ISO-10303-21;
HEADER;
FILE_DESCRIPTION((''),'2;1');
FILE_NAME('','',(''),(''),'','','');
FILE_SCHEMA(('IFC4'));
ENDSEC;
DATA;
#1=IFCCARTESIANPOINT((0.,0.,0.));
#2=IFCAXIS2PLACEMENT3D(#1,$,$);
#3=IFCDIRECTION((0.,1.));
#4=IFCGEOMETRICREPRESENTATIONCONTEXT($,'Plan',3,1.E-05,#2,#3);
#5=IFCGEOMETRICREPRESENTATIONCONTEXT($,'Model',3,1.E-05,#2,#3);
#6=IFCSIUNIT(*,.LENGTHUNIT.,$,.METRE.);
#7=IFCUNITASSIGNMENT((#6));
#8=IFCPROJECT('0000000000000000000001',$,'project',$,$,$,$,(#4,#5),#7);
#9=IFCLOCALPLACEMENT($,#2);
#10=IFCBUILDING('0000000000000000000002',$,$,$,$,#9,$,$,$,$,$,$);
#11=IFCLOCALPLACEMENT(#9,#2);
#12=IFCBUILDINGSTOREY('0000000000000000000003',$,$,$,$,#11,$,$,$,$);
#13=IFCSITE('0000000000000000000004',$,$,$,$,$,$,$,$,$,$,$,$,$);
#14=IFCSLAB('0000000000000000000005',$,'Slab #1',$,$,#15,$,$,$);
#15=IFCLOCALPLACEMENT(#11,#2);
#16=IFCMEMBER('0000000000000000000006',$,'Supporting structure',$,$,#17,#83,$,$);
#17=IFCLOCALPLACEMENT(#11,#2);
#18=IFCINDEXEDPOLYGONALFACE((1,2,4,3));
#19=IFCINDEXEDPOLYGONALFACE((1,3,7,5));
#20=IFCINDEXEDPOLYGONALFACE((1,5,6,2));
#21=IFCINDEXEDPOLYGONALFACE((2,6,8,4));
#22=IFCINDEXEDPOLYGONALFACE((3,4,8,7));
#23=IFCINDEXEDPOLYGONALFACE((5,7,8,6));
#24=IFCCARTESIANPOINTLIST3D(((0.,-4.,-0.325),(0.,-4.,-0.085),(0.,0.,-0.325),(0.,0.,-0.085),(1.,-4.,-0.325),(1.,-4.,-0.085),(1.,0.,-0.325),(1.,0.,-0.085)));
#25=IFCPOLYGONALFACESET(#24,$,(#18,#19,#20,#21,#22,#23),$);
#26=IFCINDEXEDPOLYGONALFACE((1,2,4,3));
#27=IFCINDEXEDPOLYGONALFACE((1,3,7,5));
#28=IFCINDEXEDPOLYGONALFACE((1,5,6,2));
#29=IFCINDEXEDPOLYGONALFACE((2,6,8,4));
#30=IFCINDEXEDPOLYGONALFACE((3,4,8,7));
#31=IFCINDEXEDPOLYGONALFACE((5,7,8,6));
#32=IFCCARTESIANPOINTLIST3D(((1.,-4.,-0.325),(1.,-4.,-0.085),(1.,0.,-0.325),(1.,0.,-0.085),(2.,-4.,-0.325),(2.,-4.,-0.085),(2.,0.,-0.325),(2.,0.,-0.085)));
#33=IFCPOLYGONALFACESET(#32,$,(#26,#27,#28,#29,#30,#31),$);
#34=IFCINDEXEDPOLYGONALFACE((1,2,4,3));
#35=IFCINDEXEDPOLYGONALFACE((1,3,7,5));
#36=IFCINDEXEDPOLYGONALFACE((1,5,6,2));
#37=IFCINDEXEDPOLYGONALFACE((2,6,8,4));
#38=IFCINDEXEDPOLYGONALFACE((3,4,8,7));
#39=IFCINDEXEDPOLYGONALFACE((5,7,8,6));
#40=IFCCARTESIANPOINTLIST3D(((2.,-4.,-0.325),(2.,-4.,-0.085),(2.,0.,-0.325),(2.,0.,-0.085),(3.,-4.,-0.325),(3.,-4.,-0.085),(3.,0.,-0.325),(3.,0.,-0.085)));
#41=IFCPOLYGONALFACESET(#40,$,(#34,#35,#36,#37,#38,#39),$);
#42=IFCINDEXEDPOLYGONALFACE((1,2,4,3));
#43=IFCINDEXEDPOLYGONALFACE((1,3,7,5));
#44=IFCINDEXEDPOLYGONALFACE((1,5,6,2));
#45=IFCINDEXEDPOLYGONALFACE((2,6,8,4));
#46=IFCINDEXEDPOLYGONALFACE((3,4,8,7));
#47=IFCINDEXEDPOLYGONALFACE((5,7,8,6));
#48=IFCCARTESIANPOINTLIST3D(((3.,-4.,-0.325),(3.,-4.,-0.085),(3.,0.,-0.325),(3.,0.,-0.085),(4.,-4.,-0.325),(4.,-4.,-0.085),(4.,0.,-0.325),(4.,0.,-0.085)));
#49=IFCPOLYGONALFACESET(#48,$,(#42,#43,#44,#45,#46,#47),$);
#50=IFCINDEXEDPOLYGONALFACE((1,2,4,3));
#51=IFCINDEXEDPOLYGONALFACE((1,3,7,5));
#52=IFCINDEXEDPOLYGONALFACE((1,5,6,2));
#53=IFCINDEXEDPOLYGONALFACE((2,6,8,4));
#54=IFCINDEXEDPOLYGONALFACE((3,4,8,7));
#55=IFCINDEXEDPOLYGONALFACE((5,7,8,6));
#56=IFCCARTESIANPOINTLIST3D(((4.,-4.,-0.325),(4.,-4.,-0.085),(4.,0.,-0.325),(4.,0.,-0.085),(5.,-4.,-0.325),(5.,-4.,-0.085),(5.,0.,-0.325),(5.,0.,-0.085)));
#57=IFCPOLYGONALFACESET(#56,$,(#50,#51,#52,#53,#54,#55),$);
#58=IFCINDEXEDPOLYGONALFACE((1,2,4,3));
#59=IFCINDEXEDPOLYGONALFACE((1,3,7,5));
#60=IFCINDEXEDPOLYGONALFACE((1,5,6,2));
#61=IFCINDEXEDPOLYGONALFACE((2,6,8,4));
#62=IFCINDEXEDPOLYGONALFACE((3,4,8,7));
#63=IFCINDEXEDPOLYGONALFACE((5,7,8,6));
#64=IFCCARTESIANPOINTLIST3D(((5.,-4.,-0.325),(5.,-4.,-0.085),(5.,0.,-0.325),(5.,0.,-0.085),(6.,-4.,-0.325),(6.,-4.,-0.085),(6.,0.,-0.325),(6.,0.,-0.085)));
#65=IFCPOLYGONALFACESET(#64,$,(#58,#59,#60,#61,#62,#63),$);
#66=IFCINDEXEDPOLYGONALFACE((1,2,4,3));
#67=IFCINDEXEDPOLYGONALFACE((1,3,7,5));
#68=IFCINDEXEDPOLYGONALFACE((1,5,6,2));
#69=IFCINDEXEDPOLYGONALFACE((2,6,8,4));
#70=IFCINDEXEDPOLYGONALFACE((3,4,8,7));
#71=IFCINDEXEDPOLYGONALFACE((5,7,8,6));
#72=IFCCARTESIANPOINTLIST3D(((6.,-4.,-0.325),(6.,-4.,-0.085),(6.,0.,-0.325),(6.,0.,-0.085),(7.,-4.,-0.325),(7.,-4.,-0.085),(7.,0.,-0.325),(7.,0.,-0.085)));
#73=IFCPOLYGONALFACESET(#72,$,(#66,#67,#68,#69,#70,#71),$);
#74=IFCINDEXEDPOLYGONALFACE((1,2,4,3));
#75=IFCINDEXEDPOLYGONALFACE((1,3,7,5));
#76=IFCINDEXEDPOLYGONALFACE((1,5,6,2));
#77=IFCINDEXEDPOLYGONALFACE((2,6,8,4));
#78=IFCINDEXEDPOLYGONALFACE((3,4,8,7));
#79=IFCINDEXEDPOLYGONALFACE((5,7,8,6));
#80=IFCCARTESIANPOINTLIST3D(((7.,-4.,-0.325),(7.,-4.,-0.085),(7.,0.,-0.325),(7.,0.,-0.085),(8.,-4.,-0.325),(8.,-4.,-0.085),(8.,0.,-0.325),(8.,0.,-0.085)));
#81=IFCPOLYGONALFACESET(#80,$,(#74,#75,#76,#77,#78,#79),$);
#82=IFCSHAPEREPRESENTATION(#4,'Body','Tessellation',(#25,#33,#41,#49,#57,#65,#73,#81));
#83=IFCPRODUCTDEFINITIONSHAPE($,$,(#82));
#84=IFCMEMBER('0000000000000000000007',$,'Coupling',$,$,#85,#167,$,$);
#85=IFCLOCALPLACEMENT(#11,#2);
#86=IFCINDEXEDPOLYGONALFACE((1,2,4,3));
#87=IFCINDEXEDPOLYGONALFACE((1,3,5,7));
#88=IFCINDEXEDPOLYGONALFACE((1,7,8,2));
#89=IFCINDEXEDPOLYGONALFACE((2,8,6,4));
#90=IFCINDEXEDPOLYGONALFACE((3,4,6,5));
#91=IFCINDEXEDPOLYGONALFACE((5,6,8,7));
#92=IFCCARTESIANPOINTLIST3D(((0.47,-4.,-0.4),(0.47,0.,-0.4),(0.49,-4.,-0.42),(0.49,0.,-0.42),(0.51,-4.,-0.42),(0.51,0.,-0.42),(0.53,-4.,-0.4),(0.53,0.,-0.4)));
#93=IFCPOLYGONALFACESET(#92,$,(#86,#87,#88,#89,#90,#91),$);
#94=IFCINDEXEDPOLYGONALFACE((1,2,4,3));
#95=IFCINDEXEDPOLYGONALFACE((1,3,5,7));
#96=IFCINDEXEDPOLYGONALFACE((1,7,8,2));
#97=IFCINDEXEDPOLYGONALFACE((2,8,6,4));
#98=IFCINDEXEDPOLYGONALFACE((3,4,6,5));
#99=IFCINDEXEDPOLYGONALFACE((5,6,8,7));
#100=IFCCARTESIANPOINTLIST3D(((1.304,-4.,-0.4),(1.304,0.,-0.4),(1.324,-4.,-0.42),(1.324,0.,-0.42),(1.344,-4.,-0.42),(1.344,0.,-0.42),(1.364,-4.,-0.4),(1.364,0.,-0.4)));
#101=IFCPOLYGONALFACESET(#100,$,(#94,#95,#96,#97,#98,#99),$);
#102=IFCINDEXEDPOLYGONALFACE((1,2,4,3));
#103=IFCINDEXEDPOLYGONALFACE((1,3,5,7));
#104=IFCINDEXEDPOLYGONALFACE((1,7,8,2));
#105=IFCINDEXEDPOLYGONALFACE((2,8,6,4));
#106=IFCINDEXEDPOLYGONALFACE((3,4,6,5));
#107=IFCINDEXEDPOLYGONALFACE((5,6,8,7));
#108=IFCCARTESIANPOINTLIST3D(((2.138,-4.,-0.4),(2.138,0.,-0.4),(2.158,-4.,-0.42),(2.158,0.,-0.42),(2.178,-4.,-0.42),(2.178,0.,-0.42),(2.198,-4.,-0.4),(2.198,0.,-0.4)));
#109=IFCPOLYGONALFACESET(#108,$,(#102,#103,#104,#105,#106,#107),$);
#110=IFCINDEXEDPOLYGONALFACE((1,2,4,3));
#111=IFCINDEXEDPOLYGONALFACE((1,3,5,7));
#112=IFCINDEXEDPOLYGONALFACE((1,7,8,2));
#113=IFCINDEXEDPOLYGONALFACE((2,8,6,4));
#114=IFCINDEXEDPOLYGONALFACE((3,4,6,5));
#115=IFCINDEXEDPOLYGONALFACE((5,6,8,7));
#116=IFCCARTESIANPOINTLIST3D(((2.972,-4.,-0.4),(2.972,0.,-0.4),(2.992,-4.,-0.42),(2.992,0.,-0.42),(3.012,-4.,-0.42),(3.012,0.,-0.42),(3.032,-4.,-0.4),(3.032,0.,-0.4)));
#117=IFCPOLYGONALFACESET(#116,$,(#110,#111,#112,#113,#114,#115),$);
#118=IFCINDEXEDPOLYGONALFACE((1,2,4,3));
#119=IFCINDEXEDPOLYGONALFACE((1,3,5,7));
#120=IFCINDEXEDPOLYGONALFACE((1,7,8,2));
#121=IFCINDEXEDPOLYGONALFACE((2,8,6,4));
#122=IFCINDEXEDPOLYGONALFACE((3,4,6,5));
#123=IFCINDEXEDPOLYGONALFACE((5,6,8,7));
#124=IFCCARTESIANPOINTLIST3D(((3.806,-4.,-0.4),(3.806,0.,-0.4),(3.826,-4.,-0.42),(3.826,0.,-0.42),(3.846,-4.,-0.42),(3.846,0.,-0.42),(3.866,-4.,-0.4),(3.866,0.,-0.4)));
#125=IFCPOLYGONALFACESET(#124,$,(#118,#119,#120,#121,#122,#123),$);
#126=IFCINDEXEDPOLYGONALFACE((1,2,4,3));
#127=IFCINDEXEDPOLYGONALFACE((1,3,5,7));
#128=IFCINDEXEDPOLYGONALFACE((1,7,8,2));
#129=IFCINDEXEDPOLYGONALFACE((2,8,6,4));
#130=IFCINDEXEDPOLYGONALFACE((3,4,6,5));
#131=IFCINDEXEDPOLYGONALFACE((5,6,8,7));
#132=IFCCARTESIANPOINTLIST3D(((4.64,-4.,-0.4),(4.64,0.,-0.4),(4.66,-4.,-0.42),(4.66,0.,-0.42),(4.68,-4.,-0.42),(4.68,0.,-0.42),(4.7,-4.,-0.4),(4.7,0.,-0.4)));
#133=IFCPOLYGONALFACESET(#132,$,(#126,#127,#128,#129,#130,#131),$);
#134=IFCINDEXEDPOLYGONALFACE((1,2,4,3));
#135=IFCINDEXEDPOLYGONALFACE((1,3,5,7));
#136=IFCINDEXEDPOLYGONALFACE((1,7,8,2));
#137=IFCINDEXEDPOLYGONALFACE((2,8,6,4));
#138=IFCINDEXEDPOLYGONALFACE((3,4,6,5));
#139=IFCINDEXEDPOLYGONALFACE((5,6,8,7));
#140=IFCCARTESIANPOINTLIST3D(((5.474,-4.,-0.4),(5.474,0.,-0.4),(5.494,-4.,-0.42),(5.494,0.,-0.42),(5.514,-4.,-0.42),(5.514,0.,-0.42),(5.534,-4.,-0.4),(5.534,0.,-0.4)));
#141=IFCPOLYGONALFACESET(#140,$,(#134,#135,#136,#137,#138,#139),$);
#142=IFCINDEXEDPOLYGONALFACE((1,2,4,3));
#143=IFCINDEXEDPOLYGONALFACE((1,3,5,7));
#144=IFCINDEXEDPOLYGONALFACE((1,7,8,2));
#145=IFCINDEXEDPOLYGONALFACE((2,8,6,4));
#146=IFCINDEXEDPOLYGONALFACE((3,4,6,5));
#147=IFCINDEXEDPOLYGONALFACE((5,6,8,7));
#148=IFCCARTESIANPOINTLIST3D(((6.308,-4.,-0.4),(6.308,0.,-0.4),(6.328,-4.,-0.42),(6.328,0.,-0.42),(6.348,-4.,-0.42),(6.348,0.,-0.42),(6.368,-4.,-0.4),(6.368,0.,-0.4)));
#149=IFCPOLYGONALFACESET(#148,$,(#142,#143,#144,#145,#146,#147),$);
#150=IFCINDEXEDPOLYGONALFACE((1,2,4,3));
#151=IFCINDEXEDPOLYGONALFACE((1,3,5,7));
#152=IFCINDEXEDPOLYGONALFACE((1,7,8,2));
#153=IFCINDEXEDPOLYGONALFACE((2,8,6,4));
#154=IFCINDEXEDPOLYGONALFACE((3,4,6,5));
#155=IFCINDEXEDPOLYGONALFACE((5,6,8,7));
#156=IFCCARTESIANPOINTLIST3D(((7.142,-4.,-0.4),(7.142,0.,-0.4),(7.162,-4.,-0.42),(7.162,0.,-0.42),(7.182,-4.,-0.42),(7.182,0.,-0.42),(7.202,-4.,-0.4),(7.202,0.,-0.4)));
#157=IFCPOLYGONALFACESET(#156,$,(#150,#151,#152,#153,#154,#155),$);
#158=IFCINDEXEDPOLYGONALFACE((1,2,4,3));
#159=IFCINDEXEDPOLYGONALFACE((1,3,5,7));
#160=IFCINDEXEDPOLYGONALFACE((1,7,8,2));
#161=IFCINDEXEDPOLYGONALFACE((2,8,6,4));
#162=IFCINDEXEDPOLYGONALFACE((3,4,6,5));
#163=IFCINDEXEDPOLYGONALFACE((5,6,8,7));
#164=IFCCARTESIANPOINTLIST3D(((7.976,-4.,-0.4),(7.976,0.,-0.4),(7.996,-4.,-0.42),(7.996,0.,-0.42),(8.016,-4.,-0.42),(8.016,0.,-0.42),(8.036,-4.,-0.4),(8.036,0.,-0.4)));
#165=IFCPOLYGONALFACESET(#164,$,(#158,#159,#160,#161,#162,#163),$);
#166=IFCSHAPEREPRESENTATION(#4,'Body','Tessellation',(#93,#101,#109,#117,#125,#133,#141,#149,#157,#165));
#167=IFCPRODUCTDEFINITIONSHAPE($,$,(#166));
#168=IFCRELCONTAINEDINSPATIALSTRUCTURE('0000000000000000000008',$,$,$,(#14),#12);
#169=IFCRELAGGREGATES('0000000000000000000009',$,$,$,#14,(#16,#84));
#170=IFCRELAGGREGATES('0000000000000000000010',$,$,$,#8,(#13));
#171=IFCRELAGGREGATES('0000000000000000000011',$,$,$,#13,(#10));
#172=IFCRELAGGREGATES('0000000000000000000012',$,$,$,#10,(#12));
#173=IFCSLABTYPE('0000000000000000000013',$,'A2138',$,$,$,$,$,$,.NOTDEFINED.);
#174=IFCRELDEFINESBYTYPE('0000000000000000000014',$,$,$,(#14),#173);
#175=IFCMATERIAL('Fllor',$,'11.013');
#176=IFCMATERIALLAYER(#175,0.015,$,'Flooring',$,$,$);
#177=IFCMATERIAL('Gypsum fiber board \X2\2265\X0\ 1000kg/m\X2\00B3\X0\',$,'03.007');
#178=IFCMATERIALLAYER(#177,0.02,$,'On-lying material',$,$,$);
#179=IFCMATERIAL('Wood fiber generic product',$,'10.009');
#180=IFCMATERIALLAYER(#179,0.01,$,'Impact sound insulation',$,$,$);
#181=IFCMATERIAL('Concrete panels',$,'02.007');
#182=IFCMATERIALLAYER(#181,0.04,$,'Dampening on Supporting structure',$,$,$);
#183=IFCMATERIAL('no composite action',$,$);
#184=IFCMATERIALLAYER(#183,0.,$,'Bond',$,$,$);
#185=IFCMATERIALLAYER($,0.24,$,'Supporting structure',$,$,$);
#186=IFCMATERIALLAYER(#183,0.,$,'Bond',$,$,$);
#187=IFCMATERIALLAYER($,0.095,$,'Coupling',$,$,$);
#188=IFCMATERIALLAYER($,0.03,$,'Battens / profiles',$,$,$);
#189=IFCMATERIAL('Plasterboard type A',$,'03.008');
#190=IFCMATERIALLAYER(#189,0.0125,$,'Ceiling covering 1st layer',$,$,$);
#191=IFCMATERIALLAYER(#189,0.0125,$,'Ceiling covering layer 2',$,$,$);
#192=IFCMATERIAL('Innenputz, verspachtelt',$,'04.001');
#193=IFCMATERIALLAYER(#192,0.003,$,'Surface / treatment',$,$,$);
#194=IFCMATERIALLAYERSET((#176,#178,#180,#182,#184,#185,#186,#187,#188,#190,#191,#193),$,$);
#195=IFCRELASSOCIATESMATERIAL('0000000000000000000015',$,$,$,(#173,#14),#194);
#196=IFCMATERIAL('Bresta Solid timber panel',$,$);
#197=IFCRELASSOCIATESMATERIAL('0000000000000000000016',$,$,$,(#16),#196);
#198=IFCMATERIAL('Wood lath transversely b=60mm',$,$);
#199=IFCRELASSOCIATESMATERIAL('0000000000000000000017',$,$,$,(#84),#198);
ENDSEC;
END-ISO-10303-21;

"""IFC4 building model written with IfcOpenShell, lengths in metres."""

from ifc_helpers import new_model, si_unit, direction, frame, frame_2d, origin, place, context, project, spatial, polyline, rectangle, outline, extrude, material, layer, layer_set, type_object, element, aggregate, save


model = new_model("IFC4")

# Units and contexts
plan_context = context("Plan", 3, precision=1e-05, world=origin(), true_north=direction((0.0, 1.0)))
model_context = context("Model", 3, precision=1e-05, world=origin(), true_north=direction((0.0, 1.0)))
ifc_project = project(units=[si_unit("LENGTHUNIT", "METRE")], contexts=[plan_context, model_context])

# Site, building, storey
site = spatial("IfcSite", under=ifc_project)
building_placement = place(None, origin())
building = spatial("IfcBuilding", under=site, at=building_placement)
storey_placement = place(building_placement, origin())
storey = spatial("IfcBuildingStorey", under=building, at=storey_placement)

# Slab, members
ifc_material_1 = material(Name="Fllor", Category="11.013")
ifc_layer_1 = layer(ifc_material_1, 0.015, Name="Flooring")
ifc_material_2 = material(Name="Gypsum fiber board ≥ 1000kg/m³", Category="03.007")
ifc_layer_2 = layer(ifc_material_2, 0.02, Name="On-lying material")
ifc_material_3 = material(Name="Wood fiber generic product", Category="10.009")
ifc_layer_3 = layer(ifc_material_3, 0.01, Name="Impact sound insulation")
ifc_material_4 = material(Name="Concrete panels", Category="02.007")
ifc_layer_4 = layer(ifc_material_4, 0.04, Name="Dampening on Supporting structure")
ifc_material_5 = material(Name="no composite action")
ifc_layer_5 = layer(ifc_material_5, 0.0, Name="Bond")
ifc_layer_6 = layer(None, 0.24, Name="Supporting structure")
ifc_layer_7 = layer(ifc_material_5, 0.0, Name="Bond")
ifc_layer_8 = layer(None, 0.095, Name="Coupling")
ifc_layer_9 = layer(None, 0.03, Name="Battens / profiles")
ifc_material_6 = material(Name="Plasterboard type A", Category="03.008")
ifc_layer_10 = layer(ifc_material_6, 0.0125, Name="Ceiling covering 1st layer")
ifc_layer_11 = layer(ifc_material_6, 0.0125, Name="Ceiling covering layer 2")
ifc_material_7 = material(Name="Innenputz, verspachtelt", Category="04.001")
ifc_layer_12 = layer(ifc_material_7, 0.003, Name="Surface / treatment")
ifc_layer_set = layer_set([ifc_layer_1, ifc_layer_2, ifc_layer_3, ifc_layer_4, ifc_layer_5, ifc_layer_6, ifc_layer_7, ifc_layer_8, ifc_layer_9, ifc_layer_10, ifc_layer_11, ifc_layer_12])
slab_type = type_object("IfcSlabType", Name="A2138", PredefinedType="NOTDEFINED", material=ifc_layer_set)
slab_placement = place(None, frame((0.0, 0.0, 0.0), z_axis=(0.0, 0.0, -1.0), x_axis=(1.0, 0.0, 0.0)))
slab = element("IfcSlab", 1, at=slab_placement, inside=storey, type_object=slab_type, material=ifc_layer_set, Name="Slab #1")
ifc_material_8 = material(Name="Bresta Solid timber panel")
member_1_placement = place(slab_placement, origin())
member_1 = element("IfcMember", 2, at=member_1_placement, material=ifc_material_8, Name="Supporting structure", context=plan_context, shape_type="SweptSolid", body=[
    extrude(rectangle(XDim=1.0, YDim=0.24, at=frame_2d((0.5, 0.12), x_axis=(1.0, 0.0))), frame((0.0, 4.0, 0.085), z_axis=(0.0, -1.0, 0.0), x_axis=(1.0, 0.0, 0.0)), (0.0, 0.0, 1.0), 4.0),
    extrude(rectangle(XDim=1.0, YDim=0.24, at=frame_2d((0.5, 0.12), x_axis=(1.0, 0.0))), frame((1.0, 4.0, 0.085), z_axis=(0.0, -1.0, 0.0), x_axis=(1.0, 0.0, 0.0)), (0.0, 0.0, 1.0), 4.0),
    extrude(rectangle(XDim=1.0, YDim=0.24, at=frame_2d((0.5, 0.12), x_axis=(1.0, 0.0))), frame((2.0, 4.0, 0.085), z_axis=(0.0, -1.0, 0.0), x_axis=(1.0, 0.0, 0.0)), (0.0, 0.0, 1.0), 4.0),
    extrude(rectangle(XDim=1.0, YDim=0.24, at=frame_2d((0.5, 0.12), x_axis=(1.0, 0.0))), frame((3.0, 4.0, 0.085), z_axis=(0.0, -1.0, 0.0), x_axis=(1.0, 0.0, 0.0)), (0.0, 0.0, 1.0), 4.0),
    extrude(rectangle(XDim=1.0, YDim=0.24, at=frame_2d((0.5, 0.12), x_axis=(1.0, 0.0))), frame((4.0, 4.0, 0.085), z_axis=(0.0, -1.0, 0.0), x_axis=(1.0, 0.0, 0.0)), (0.0, 0.0, 1.0), 4.0),
    extrude(rectangle(XDim=1.0, YDim=0.24, at=frame_2d((0.5, 0.12), x_axis=(1.0, 0.0))), frame((5.0, 4.0, 0.085), z_axis=(0.0, -1.0, 0.0), x_axis=(1.0, 0.0, 0.0)), (0.0, 0.0, 1.0), 4.0),
    extrude(rectangle(XDim=1.0, YDim=0.24, at=frame_2d((0.5, 0.12), x_axis=(1.0, 0.0))), frame((6.0, 4.0, 0.085), z_axis=(0.0, -1.0, 0.0), x_axis=(1.0, 0.0, 0.0)), (0.0, 0.0, 1.0), 4.0),
    extrude(rectangle(XDim=1.0, YDim=0.24, at=frame_2d((0.5, 0.12), x_axis=(1.0, 0.0))), frame((7.0, 4.0, 0.085), z_axis=(0.0, -1.0, 0.0), x_axis=(1.0, 0.0, 0.0)), (0.0, 0.0, 1.0), 4.0),
])
ifc_material_9 = material(Name="Wood lath transversely b=60mm")
member_2_placement = place(slab_placement, origin())
member_2 = element("IfcMember", 3, at=member_2_placement, material=ifc_material_9, Name="Coupling", context=plan_context, shape_type="SweptSolid", body=[
    extrude(outline(polyline([(0.0, 0.0), (0.06, 0.0), (0.04, 0.02), (0.02, 0.02), (0.0, 0.0)])), frame((0.47, 4.0, 0.4), z_axis=(0.0, -1.0, 0.0), x_axis=(1.0, 0.0, 0.0)), (0.0, 0.0, 1.0), 4.0),
    extrude(outline(polyline([(0.0, 0.0), (0.06, 0.0), (0.04, 0.02), (0.02, 0.02), (0.0, 0.0)])), frame((1.304, 4.0, 0.4), z_axis=(0.0, -1.0, 0.0), x_axis=(1.0, 0.0, 0.0)), (0.0, 0.0, 1.0), 4.0),
    extrude(outline(polyline([(0.0, 0.0), (0.06, 0.0), (0.04, 0.02), (0.02, 0.02), (0.0, 0.0)])), frame((2.138, 4.0, 0.4), z_axis=(0.0, -1.0, 0.0), x_axis=(1.0, 0.0, 0.0)), (0.0, 0.0, 1.0), 4.0),
    extrude(outline(polyline([(0.0, 0.0), (0.06, 0.0), (0.04, 0.02), (0.02, 0.02), (0.0, 0.0)])), frame((2.972, 4.0, 0.4), z_axis=(0.0, -1.0, 0.0), x_axis=(1.0, 0.0, 0.0)), (0.0, 0.0, 1.0), 4.0),
    extrude(outline(polyline([(0.0, 0.0), (0.06, 0.0), (0.04, 0.02), (0.02, 0.02), (0.0, 0.0)])), frame((3.806, 4.0, 0.4), z_axis=(0.0, -1.0, 0.0), x_axis=(1.0, 0.0, 0.0)), (0.0, 0.0, 1.0), 4.0),
    extrude(outline(polyline([(0.0, 0.0), (0.06, 0.0), (0.04, 0.02), (0.02, 0.02), (0.0, 0.0)])), frame((4.64, 4.0, 0.4), z_axis=(0.0, -1.0, 0.0), x_axis=(1.0, 0.0, 0.0)), (0.0, 0.0, 1.0), 4.0),
    extrude(outline(polyline([(0.0, 0.0), (0.06, 0.0), (0.04, 0.02), (0.02, 0.02), (0.0, 0.0)])), frame((5.474, 4.0, 0.4), z_axis=(0.0, -1.0, 0.0), x_axis=(1.0, 0.0, 0.0)), (0.0, 0.0, 1.0), 4.0),
    extrude(outline(polyline([(0.0, 0.0), (0.06, 0.0), (0.04, 0.02), (0.02, 0.02), (0.0, 0.0)])), frame((6.308, 4.0, 0.4), z_axis=(0.0, -1.0, 0.0), x_axis=(1.0, 0.0, 0.0)), (0.0, 0.0, 1.0), 4.0),
    extrude(outline(polyline([(0.0, 0.0), (0.06, 0.0), (0.04, 0.02), (0.02, 0.02), (0.0, 0.0)])), frame((7.142, 4.0, 0.4), z_axis=(0.0, -1.0, 0.0), x_axis=(1.0, 0.0, 0.0)), (0.0, 0.0, 1.0), 4.0),
    extrude(outline(polyline([(0.0, 0.0), (0.06, 0.0), (0.04, 0.02), (0.02, 0.02), (0.0, 0.0)])), frame((7.976, 4.0, 0.4), z_axis=(0.0, -1.0, 0.0), x_axis=(1.0, 0.0, 0.0)), (0.0, 0.0, 1.0), 4.0),
])
aggregate(slab, [member_1, member_2])

save(model, "model.ifc")
